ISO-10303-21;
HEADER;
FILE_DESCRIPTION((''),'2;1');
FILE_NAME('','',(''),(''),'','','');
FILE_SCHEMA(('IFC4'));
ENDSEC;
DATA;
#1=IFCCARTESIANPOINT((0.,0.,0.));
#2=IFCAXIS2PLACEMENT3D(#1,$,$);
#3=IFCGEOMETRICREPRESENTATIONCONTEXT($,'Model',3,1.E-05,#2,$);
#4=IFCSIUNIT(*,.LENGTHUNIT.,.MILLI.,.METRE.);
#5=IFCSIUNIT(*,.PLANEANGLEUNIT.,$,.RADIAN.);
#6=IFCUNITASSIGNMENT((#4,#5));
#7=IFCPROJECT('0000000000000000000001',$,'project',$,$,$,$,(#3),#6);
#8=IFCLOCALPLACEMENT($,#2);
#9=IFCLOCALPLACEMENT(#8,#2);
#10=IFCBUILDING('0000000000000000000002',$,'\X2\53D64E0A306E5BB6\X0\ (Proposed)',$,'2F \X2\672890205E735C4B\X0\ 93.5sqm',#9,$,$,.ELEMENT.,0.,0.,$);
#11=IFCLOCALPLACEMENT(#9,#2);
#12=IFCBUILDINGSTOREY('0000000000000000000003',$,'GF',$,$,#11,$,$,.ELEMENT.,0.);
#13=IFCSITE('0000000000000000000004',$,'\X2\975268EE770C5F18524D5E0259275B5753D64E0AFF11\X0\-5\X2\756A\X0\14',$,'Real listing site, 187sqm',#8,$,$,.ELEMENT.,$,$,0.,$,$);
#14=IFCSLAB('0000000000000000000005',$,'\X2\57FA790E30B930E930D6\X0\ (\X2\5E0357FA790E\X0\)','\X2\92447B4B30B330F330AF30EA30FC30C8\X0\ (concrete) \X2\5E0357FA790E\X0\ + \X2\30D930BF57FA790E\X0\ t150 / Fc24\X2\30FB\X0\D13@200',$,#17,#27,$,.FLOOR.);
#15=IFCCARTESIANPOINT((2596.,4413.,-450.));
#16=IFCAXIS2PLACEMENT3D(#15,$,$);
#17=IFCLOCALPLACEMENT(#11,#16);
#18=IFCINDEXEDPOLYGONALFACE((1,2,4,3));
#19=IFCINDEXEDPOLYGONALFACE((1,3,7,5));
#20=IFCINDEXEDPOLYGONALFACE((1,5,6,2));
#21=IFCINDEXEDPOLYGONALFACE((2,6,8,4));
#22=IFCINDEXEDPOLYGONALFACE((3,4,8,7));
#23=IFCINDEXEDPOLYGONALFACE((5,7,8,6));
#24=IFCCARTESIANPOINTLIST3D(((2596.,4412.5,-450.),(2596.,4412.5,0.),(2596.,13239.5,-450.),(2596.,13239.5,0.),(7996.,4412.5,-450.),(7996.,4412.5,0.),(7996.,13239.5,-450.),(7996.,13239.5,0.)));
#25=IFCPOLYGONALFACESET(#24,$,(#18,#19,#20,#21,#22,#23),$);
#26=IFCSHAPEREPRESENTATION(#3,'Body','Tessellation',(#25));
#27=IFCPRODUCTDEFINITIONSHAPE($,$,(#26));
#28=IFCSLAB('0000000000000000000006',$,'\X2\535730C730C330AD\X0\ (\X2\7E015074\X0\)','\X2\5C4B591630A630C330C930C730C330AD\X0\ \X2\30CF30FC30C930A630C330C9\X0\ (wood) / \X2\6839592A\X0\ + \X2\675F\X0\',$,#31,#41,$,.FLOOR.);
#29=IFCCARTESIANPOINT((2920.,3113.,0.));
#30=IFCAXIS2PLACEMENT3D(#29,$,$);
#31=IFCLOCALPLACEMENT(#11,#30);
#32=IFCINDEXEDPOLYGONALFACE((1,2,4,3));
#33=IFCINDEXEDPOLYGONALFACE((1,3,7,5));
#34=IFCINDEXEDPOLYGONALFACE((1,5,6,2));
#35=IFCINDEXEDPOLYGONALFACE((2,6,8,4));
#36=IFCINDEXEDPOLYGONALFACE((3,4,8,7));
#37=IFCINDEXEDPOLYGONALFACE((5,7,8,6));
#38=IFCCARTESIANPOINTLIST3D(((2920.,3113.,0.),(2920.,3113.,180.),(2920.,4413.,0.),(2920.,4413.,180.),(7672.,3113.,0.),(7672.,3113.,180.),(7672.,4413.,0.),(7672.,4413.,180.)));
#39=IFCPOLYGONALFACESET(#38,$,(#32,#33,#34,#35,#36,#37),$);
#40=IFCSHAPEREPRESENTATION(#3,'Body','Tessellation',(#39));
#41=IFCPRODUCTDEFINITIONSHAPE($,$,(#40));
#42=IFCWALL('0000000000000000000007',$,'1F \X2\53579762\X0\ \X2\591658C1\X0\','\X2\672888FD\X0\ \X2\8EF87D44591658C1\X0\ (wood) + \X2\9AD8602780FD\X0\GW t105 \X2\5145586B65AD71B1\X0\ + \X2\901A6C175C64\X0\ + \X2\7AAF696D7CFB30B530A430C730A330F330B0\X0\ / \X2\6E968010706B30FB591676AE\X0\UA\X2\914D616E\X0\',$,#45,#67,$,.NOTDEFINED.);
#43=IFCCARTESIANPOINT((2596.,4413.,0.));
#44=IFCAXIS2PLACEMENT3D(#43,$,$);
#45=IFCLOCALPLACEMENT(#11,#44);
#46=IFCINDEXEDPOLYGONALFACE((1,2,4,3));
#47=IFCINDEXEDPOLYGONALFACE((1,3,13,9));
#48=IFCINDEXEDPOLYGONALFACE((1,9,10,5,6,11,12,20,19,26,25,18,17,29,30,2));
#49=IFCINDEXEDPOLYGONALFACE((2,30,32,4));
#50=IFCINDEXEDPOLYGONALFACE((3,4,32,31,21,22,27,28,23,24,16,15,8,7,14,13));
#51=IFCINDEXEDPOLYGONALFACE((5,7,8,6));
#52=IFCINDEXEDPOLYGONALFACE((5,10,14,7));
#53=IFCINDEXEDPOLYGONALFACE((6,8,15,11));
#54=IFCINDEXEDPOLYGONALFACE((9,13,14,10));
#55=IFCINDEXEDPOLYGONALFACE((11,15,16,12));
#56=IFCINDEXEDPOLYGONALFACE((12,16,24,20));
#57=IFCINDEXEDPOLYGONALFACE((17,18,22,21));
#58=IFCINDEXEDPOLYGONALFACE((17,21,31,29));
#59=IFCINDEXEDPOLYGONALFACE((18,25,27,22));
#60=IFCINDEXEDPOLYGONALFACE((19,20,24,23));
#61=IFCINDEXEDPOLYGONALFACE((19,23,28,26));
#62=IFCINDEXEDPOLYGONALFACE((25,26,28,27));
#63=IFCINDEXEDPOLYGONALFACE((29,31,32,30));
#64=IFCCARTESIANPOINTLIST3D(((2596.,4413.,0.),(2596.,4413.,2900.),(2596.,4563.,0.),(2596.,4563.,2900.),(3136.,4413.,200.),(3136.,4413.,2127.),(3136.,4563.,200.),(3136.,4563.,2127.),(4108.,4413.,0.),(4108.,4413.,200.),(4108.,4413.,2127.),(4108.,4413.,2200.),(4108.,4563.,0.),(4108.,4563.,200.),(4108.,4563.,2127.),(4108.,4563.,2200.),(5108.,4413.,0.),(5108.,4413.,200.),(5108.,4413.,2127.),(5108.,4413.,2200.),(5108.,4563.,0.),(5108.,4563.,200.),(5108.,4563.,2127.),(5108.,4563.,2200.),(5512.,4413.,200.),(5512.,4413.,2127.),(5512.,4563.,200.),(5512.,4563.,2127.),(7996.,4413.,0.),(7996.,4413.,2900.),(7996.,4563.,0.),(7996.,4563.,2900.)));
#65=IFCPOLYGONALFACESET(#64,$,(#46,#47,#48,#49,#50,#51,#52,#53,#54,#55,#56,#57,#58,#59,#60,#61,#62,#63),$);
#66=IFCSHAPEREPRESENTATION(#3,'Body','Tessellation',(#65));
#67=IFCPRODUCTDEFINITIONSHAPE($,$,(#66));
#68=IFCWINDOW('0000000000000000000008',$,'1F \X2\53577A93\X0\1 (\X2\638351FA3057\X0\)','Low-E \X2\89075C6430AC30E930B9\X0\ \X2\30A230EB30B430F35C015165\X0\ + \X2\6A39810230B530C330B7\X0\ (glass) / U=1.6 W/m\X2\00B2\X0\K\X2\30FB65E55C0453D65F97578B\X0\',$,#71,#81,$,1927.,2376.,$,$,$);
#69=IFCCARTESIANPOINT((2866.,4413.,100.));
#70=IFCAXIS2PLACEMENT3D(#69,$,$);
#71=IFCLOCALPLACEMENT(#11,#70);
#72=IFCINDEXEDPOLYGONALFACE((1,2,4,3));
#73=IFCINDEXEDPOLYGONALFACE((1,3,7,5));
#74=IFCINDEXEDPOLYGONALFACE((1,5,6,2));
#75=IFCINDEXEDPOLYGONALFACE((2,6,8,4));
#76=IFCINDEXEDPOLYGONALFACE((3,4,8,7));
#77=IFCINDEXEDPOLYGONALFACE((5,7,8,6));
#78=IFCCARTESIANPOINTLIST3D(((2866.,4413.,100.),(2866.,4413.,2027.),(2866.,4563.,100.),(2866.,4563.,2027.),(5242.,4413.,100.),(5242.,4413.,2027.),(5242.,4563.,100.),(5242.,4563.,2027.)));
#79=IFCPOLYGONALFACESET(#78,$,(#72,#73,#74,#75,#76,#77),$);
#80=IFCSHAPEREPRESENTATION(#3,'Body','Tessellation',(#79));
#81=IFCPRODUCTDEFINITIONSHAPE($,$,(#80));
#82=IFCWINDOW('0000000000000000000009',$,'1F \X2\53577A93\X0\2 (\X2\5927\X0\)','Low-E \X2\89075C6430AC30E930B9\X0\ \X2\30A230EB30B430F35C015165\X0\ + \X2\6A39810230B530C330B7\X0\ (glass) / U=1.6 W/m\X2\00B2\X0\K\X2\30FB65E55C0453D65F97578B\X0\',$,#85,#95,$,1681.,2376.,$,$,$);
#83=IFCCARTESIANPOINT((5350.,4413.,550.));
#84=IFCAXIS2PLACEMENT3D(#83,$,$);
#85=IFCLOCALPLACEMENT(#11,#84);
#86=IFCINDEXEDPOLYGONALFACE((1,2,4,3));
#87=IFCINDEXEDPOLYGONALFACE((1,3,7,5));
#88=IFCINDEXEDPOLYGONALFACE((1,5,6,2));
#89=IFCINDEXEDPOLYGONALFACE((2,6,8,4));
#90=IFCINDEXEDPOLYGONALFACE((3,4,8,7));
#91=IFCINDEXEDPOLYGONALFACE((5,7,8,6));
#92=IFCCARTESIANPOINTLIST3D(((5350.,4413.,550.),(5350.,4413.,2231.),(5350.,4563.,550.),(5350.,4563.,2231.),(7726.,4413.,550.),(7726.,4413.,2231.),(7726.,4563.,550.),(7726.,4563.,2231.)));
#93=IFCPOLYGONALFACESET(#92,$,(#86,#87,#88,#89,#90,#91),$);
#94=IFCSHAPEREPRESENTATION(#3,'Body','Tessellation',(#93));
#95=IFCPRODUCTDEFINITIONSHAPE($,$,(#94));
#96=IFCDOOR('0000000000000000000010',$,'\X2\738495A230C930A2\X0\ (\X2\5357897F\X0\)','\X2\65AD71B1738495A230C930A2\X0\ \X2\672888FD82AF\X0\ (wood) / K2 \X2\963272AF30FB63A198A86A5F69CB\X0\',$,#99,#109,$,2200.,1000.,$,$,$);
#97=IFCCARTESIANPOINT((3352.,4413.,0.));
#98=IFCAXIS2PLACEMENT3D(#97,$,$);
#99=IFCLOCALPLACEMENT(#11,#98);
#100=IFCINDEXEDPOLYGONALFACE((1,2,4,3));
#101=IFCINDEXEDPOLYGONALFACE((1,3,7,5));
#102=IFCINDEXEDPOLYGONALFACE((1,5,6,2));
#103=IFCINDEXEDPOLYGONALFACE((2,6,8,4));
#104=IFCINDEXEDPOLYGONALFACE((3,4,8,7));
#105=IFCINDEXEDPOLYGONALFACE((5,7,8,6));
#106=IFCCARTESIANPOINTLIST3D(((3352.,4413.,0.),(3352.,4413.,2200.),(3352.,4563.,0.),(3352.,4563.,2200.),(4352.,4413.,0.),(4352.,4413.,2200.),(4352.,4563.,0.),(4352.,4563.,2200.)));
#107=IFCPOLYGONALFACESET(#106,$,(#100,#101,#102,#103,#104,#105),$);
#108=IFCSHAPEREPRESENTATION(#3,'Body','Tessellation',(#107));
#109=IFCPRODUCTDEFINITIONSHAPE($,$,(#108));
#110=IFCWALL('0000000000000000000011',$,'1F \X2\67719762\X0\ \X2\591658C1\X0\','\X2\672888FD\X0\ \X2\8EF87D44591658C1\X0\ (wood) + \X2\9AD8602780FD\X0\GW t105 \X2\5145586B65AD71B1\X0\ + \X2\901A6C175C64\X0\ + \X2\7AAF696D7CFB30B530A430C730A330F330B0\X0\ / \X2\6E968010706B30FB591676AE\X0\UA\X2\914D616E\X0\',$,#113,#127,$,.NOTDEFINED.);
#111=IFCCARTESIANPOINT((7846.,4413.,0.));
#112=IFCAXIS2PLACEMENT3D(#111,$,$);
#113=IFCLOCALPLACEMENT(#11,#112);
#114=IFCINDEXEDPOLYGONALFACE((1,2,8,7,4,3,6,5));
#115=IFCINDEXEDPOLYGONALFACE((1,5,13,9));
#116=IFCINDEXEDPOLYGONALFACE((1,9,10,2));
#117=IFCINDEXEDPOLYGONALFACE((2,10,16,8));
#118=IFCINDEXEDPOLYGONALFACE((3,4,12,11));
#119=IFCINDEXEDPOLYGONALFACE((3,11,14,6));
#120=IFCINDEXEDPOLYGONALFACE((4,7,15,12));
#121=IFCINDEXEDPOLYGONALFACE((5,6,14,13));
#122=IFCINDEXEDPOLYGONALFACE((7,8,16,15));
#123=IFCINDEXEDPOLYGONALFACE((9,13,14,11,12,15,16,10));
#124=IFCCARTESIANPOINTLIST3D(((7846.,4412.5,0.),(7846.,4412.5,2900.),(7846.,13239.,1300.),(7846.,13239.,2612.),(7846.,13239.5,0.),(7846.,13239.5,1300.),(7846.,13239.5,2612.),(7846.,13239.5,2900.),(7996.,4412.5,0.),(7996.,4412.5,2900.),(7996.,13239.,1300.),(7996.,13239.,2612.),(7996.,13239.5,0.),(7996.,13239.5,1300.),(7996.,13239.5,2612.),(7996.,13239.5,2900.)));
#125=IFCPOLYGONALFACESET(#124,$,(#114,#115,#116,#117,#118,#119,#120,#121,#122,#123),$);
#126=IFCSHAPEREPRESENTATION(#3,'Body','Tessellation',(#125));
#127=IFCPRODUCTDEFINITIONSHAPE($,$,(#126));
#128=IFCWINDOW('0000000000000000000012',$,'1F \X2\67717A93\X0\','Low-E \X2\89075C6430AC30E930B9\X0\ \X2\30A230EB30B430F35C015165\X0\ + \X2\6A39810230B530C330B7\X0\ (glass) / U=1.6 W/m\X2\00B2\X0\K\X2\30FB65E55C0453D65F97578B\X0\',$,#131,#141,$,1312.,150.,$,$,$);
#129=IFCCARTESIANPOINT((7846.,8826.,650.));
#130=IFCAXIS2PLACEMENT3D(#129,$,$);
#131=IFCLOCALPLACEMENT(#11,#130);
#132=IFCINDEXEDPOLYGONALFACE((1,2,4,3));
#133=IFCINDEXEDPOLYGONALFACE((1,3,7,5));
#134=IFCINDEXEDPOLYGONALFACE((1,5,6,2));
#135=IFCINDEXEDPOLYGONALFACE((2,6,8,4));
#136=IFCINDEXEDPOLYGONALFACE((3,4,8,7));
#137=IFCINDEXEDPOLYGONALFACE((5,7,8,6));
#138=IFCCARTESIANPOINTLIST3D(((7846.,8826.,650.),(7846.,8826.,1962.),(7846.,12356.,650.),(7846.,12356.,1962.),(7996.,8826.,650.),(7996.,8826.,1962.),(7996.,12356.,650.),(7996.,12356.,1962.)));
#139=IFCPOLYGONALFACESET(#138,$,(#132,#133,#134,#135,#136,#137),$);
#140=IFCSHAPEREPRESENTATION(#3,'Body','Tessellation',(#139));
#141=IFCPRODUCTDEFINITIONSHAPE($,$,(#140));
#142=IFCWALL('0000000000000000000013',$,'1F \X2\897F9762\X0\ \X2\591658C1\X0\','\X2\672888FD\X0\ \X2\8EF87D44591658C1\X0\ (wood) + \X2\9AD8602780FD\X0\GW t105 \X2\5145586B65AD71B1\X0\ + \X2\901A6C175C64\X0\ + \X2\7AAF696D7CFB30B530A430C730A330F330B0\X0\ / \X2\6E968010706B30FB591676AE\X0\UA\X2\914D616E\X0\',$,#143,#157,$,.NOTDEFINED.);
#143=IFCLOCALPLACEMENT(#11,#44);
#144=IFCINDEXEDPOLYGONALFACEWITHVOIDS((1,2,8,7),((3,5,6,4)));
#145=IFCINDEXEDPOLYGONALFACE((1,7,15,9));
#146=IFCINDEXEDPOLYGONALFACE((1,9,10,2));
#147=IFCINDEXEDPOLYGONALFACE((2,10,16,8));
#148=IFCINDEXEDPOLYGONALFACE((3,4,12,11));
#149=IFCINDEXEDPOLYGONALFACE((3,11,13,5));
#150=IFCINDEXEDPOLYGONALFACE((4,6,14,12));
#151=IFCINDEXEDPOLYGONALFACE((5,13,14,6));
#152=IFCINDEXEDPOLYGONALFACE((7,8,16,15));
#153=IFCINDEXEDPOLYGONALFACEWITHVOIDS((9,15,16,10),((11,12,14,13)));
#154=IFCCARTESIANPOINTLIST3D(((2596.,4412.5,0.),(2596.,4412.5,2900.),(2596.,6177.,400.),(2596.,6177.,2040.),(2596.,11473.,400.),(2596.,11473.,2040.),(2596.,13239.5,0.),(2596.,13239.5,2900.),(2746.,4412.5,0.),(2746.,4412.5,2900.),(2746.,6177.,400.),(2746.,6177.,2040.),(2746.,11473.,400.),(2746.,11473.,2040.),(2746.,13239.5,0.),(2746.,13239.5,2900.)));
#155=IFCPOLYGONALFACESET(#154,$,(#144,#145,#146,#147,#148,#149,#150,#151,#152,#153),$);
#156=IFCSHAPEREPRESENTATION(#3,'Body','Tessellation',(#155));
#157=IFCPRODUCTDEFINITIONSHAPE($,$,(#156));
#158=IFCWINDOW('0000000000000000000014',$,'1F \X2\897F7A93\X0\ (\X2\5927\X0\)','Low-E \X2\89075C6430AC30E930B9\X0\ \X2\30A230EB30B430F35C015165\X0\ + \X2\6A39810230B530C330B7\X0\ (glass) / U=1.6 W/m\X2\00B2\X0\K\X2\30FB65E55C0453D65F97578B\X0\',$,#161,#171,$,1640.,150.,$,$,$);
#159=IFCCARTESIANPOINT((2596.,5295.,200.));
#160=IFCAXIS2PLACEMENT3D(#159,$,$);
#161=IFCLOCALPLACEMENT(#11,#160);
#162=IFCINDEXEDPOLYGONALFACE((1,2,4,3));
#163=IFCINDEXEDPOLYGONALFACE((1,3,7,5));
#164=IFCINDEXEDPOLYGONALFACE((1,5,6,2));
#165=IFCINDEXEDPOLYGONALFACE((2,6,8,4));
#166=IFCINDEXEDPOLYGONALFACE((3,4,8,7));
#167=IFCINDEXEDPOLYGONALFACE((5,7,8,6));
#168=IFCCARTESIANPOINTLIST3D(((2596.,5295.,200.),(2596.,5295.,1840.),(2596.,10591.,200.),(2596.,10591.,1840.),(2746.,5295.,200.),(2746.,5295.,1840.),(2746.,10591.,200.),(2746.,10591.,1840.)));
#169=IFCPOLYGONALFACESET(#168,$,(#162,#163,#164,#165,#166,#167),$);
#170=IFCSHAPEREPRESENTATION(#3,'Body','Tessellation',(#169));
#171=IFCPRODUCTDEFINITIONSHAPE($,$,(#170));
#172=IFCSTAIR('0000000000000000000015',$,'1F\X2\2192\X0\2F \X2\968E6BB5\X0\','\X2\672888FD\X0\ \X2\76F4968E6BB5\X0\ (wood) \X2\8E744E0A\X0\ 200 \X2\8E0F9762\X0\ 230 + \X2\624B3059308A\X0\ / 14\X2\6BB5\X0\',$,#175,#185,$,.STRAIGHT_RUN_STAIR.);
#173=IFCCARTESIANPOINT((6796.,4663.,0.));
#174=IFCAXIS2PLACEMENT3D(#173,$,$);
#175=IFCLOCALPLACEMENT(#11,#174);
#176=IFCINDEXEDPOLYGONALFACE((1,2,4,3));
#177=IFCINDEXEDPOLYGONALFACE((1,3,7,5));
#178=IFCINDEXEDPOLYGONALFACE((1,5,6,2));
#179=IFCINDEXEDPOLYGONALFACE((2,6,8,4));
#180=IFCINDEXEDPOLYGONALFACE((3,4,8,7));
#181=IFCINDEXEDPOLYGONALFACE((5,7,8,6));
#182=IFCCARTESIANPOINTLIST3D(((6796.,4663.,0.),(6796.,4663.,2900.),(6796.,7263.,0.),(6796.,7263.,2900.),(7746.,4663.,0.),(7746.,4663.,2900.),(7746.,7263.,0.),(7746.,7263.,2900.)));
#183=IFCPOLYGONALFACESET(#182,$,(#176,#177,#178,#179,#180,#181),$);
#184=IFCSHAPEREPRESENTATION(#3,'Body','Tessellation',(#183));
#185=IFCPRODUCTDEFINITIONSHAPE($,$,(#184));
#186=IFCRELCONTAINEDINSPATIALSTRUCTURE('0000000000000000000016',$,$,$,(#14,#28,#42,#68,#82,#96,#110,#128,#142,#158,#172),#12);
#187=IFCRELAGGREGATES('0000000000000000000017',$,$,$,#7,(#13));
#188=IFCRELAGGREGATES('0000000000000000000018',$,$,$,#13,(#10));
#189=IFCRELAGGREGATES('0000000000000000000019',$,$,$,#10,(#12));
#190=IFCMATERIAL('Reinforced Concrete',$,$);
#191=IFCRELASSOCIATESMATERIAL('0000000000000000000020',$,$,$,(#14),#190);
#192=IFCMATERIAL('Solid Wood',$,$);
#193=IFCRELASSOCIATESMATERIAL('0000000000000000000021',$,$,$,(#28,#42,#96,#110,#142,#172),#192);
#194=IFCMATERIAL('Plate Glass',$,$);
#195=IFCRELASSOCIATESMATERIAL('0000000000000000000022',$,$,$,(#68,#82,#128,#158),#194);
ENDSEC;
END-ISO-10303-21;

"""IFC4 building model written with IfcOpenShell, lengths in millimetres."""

from ifc_helpers import new_model, si_unit, frame, frame_2d, origin, place, context, project, spatial, rectangle, extrude, material, element, fill, save


model = new_model("IFC4")

# Units and contexts
model_context = context("Model", 3, precision=1e-05, world=origin())
ifc_project = project(units=[si_unit("LENGTHUNIT", "METRE", prefix="MILLI"), si_unit("PLANEANGLEUNIT", "RADIAN")], contexts=[model_context])

# Site, building, storey
site_placement = place(None, origin())
site = spatial("IfcSite", under=ifc_project, at=site_placement, Name="青森県弘前市大字取上１-5番14", ObjectType="Real listing site, 187sqm", CompositionType="ELEMENT", RefElevation=0.0)
building_placement = place(site_placement, origin())
building = spatial("IfcBuilding", under=site, at=building_placement, Name="取上の家 (Proposed)", ObjectType="2F 木造平屋 93.5sqm", CompositionType="ELEMENT", ElevationOfRefHeight=0.0, ElevationOfTerrain=0.0)
storey_placement = place(building_placement, origin())
storey = spatial("IfcBuildingStorey", under=building, at=storey_placement, Name="GF", CompositionType="ELEMENT", Elevation=0.0)

# Slabs
ifc_material_1 = material(Name="Reinforced Concrete")
slab_1_placement = place(storey_placement, frame((2596.0, 4413.0, -450.0)))
element("IfcSlab", 1, at=slab_1_placement, inside=storey, material=ifc_material_1, Name="基礎スラブ (布基礎)", Description="鉄筋コンクリート (concrete) 布基礎 + ベタ基礎 t150 / Fc24・D13@200", PredefinedType="FLOOR", context=model_context, shape_type="SweptSolid", body=[
    extrude(rectangle(XDim=5400.0, YDim=8827.0, at=frame_2d((2700.0, 4413.0))), frame((2596.0, 4413.0, -450.0)), (0.0, 0.0, 1.0), 450.0),
])
ifc_material_2 = material(Name="Solid Wood")
slab_2_placement = place(storey_placement, frame((2920.0, 3113.0, 0.0)))
element("IfcSlab", 2, at=slab_2_placement, inside=storey, material=ifc_material_2, Name="南デッキ (縁側)", Description="屋外ウッドデッキ ハードウッド (wood) / 根太 + 束", PredefinedType="FLOOR", context=model_context, shape_type="SweptSolid", body=[
    extrude(rectangle(XDim=4752.0, YDim=1300.0, at=frame_2d((2376.0, 650.0))), frame((2920.0, 3113.0, 0.0)), (0.0, 0.0, 1.0), 180.0),
])

# Wall, openings, windows, door
wall_1_placement = place(storey_placement, frame((2596.0, 4413.0, 0.0)))
wall_1 = element("IfcWall", 3, at=wall_1_placement, inside=storey, material=ifc_material_2, Name="1F 南面 外壁", Description="木製 軸組外壁 (wood) + 高性能GW t105 充填断熱 + 通気層 + 窯業系サイディング / 準耐火・外皮UA配慮", PredefinedType="NOTDEFINED", context=model_context, shape_type="SweptSolid", body=[
    extrude(rectangle(XDim=5400.0, YDim=150.0, at=frame_2d((2700.0, 75.0))), frame((2596.0, 4413.0, 0.0)), (0.0, 0.0, 1.0), 2900.0),
])
opening_1_placement = place(storey_placement, frame((2866.0, 4413.0, 100.0)))
opening_1 = element("IfcOpeningElement", 4, at=opening_1_placement, cuts=wall_1, PredefinedType="NOTDEFINED", context=model_context, shape_type="SweptSolid", body=[
    extrude(rectangle(XDim=2376.0, YDim=150.0, at=frame_2d((1188.0, 75.0))), frame((2866.0, 4413.0, 100.0)), (0.0, 0.0, 1.0), 1927.0),
])
opening_2_placement = place(storey_placement, frame((5350.0, 4413.0, 550.0)))
opening_2 = element("IfcOpeningElement", 5, at=opening_2_placement, cuts=wall_1, PredefinedType="NOTDEFINED", context=model_context, shape_type="SweptSolid", body=[
    extrude(rectangle(XDim=2376.0, YDim=150.0, at=frame_2d((1188.0, 75.0))), frame((5350.0, 4413.0, 550.0)), (0.0, 0.0, 1.0), 1681.0),
])
opening_3_placement = place(storey_placement, frame((3352.0, 4413.0, 0.0)))
opening_3 = element("IfcOpeningElement", 6, at=opening_3_placement, cuts=wall_1, PredefinedType="NOTDEFINED", context=model_context, shape_type="SweptSolid", body=[
    extrude(rectangle(XDim=1000.0, YDim=150.0, at=frame_2d((500.0, 75.0))), frame((3352.0, 4413.0, 0.0)), (0.0, 0.0, 1.0), 2200.0),
])
ifc_material_3 = material(Name="Plate Glass")
window_1_placement = place(storey_placement, frame((2866.0, 4413.0, 100.0)))
window_1 = element("IfcWindow", 7, at=window_1_placement, inside=storey, material=ifc_material_3, Name="1F 南窓1 (掃出し)", Description="Low-E 複層ガラス アルゴン封入 + 樹脂サッシ (glass) / U=1.6 W/m²K・日射取得型", OverallHeight=1927.0, OverallWidth=2376.0, context=model_context, shape_type="SweptSolid", body=[
    extrude(rectangle(XDim=2376.0, YDim=150.0, at=frame_2d((1188.0, 75.0))), frame((2866.0, 4413.0, 100.0)), (0.0, 0.0, 1.0), 1927.0),
])
fill(opening_1, window_1)
window_2_placement = place(storey_placement, frame((5350.0, 4413.0, 550.0)))
window_2 = element("IfcWindow", 8, at=window_2_placement, inside=storey, material=ifc_material_3, Name="1F 南窓2 (大)", Description="Low-E 複層ガラス アルゴン封入 + 樹脂サッシ (glass) / U=1.6 W/m²K・日射取得型", OverallHeight=1681.0, OverallWidth=2376.0, context=model_context, shape_type="SweptSolid", body=[
    extrude(rectangle(XDim=2376.0, YDim=150.0, at=frame_2d((1188.0, 75.0))), frame((5350.0, 4413.0, 550.0)), (0.0, 0.0, 1.0), 1681.0),
])
fill(opening_2, window_2)
door_placement = place(storey_placement, frame((3352.0, 4413.0, 0.0)))
door = element("IfcDoor", 9, at=door_placement, inside=storey, material=ifc_material_2, Name="玄関ドア (南西)", Description="断熱玄関ドア 木製芯 (wood) / K2 防犯・採風機構", OverallHeight=2200.0, OverallWidth=1000.0, context=model_context, shape_type="SweptSolid", body=[
    extrude(rectangle(XDim=1000.0, YDim=150.0, at=frame_2d((500.0, 75.0))), frame((3352.0, 4413.0, 0.0)), (0.0, 0.0, 1.0), 2200.0),
])
fill(opening_3, door)

# Walls, openings, windows
wall_2_placement = place(storey_placement, frame((7846.0, 4413.0, 0.0)))
wall_2 = element("IfcWall", 10, at=wall_2_placement, inside=storey, material=ifc_material_2, Name="1F 東面 外壁", Description="木製 軸組外壁 (wood) + 高性能GW t105 充填断熱 + 通気層 + 窯業系サイディング / 準耐火・外皮UA配慮", PredefinedType="NOTDEFINED", context=model_context, shape_type="SweptSolid", body=[
    extrude(rectangle(XDim=150.0, YDim=8827.0, at=frame_2d((75.0, 4413.0))), frame((7846.0, 4413.0, 0.0)), (0.0, 0.0, 1.0), 2900.0),
])
opening_4_placement = place(storey_placement, frame((7846.0, 8826.0, 650.0)))
opening_4 = element("IfcOpeningElement", 11, at=opening_4_placement, cuts=wall_2, PredefinedType="NOTDEFINED", context=model_context, shape_type="SweptSolid", body=[
    extrude(rectangle(XDim=150.0, YDim=3530.0, at=frame_2d((75.0, 1765.0))), frame((7846.0, 8826.0, 650.0)), (0.0, 0.0, 1.0), 1312.0),
])
window_3_placement = place(storey_placement, frame((7846.0, 8826.0, 650.0)))
window_3 = element("IfcWindow", 12, at=window_3_placement, inside=storey, material=ifc_material_3, Name="1F 東窓", Description="Low-E 複層ガラス アルゴン封入 + 樹脂サッシ (glass) / U=1.6 W/m²K・日射取得型", OverallHeight=1312.0, OverallWidth=150.0, context=model_context, shape_type="SweptSolid", body=[
    extrude(rectangle(XDim=150.0, YDim=3530.0, at=frame_2d((75.0, 1765.0))), frame((7846.0, 8826.0, 650.0)), (0.0, 0.0, 1.0), 1312.0),
])
fill(opening_4, window_3)
wall_3_placement = place(storey_placement, frame((2596.0, 4413.0, 0.0)))
wall_3 = element("IfcWall", 13, at=wall_3_placement, inside=storey, material=ifc_material_2, Name="1F 西面 外壁", Description="木製 軸組外壁 (wood) + 高性能GW t105 充填断熱 + 通気層 + 窯業系サイディング / 準耐火・外皮UA配慮", PredefinedType="NOTDEFINED", context=model_context, shape_type="SweptSolid", body=[
    extrude(rectangle(XDim=150.0, YDim=8827.0, at=frame_2d((75.0, 4413.0))), frame((2596.0, 4413.0, 0.0)), (0.0, 0.0, 1.0), 2900.0),
])
opening_5_placement = place(storey_placement, frame((2596.0, 5295.0, 200.0)))
opening_5 = element("IfcOpeningElement", 14, at=opening_5_placement, cuts=wall_3, PredefinedType="NOTDEFINED", context=model_context, shape_type="SweptSolid", body=[
    extrude(rectangle(XDim=150.0, YDim=5296.0, at=frame_2d((75.0, 2648.0))), frame((2596.0, 5295.0, 200.0)), (0.0, 0.0, 1.0), 1640.0),
])
window_4_placement = place(storey_placement, frame((2596.0, 5295.0, 200.0)))
window_4 = element("IfcWindow", 15, at=window_4_placement, inside=storey, material=ifc_material_3, Name="1F 西窓 (大)", Description="Low-E 複層ガラス アルゴン封入 + 樹脂サッシ (glass) / U=1.6 W/m²K・日射取得型", OverallHeight=1640.0, OverallWidth=150.0, context=model_context, shape_type="SweptSolid", body=[
    extrude(rectangle(XDim=150.0, YDim=5296.0, at=frame_2d((75.0, 2648.0))), frame((2596.0, 5295.0, 200.0)), (0.0, 0.0, 1.0), 1640.0),
])
fill(opening_5, window_4)

# Stair
stair_placement = place(storey_placement, frame((6796.0, 4663.0, 0.0)))
element("IfcStair", 16, at=stair_placement, inside=storey, material=ifc_material_2, Name="1F→2F 階段", Description="木製 直階段 (wood) 蹴上 200 踏面 230 + 手すり / 14段", PredefinedType="STRAIGHT_RUN_STAIR", context=model_context, shape_type="SweptSolid", body=[
    extrude(rectangle(XDim=950.0, YDim=2600.0, at=frame_2d((475.0, 1300.0))), frame((6796.0, 4663.0, 0.0)), (0.0, 0.0, 1.0), 2900.0),
])

save(model, "model.ifc")
